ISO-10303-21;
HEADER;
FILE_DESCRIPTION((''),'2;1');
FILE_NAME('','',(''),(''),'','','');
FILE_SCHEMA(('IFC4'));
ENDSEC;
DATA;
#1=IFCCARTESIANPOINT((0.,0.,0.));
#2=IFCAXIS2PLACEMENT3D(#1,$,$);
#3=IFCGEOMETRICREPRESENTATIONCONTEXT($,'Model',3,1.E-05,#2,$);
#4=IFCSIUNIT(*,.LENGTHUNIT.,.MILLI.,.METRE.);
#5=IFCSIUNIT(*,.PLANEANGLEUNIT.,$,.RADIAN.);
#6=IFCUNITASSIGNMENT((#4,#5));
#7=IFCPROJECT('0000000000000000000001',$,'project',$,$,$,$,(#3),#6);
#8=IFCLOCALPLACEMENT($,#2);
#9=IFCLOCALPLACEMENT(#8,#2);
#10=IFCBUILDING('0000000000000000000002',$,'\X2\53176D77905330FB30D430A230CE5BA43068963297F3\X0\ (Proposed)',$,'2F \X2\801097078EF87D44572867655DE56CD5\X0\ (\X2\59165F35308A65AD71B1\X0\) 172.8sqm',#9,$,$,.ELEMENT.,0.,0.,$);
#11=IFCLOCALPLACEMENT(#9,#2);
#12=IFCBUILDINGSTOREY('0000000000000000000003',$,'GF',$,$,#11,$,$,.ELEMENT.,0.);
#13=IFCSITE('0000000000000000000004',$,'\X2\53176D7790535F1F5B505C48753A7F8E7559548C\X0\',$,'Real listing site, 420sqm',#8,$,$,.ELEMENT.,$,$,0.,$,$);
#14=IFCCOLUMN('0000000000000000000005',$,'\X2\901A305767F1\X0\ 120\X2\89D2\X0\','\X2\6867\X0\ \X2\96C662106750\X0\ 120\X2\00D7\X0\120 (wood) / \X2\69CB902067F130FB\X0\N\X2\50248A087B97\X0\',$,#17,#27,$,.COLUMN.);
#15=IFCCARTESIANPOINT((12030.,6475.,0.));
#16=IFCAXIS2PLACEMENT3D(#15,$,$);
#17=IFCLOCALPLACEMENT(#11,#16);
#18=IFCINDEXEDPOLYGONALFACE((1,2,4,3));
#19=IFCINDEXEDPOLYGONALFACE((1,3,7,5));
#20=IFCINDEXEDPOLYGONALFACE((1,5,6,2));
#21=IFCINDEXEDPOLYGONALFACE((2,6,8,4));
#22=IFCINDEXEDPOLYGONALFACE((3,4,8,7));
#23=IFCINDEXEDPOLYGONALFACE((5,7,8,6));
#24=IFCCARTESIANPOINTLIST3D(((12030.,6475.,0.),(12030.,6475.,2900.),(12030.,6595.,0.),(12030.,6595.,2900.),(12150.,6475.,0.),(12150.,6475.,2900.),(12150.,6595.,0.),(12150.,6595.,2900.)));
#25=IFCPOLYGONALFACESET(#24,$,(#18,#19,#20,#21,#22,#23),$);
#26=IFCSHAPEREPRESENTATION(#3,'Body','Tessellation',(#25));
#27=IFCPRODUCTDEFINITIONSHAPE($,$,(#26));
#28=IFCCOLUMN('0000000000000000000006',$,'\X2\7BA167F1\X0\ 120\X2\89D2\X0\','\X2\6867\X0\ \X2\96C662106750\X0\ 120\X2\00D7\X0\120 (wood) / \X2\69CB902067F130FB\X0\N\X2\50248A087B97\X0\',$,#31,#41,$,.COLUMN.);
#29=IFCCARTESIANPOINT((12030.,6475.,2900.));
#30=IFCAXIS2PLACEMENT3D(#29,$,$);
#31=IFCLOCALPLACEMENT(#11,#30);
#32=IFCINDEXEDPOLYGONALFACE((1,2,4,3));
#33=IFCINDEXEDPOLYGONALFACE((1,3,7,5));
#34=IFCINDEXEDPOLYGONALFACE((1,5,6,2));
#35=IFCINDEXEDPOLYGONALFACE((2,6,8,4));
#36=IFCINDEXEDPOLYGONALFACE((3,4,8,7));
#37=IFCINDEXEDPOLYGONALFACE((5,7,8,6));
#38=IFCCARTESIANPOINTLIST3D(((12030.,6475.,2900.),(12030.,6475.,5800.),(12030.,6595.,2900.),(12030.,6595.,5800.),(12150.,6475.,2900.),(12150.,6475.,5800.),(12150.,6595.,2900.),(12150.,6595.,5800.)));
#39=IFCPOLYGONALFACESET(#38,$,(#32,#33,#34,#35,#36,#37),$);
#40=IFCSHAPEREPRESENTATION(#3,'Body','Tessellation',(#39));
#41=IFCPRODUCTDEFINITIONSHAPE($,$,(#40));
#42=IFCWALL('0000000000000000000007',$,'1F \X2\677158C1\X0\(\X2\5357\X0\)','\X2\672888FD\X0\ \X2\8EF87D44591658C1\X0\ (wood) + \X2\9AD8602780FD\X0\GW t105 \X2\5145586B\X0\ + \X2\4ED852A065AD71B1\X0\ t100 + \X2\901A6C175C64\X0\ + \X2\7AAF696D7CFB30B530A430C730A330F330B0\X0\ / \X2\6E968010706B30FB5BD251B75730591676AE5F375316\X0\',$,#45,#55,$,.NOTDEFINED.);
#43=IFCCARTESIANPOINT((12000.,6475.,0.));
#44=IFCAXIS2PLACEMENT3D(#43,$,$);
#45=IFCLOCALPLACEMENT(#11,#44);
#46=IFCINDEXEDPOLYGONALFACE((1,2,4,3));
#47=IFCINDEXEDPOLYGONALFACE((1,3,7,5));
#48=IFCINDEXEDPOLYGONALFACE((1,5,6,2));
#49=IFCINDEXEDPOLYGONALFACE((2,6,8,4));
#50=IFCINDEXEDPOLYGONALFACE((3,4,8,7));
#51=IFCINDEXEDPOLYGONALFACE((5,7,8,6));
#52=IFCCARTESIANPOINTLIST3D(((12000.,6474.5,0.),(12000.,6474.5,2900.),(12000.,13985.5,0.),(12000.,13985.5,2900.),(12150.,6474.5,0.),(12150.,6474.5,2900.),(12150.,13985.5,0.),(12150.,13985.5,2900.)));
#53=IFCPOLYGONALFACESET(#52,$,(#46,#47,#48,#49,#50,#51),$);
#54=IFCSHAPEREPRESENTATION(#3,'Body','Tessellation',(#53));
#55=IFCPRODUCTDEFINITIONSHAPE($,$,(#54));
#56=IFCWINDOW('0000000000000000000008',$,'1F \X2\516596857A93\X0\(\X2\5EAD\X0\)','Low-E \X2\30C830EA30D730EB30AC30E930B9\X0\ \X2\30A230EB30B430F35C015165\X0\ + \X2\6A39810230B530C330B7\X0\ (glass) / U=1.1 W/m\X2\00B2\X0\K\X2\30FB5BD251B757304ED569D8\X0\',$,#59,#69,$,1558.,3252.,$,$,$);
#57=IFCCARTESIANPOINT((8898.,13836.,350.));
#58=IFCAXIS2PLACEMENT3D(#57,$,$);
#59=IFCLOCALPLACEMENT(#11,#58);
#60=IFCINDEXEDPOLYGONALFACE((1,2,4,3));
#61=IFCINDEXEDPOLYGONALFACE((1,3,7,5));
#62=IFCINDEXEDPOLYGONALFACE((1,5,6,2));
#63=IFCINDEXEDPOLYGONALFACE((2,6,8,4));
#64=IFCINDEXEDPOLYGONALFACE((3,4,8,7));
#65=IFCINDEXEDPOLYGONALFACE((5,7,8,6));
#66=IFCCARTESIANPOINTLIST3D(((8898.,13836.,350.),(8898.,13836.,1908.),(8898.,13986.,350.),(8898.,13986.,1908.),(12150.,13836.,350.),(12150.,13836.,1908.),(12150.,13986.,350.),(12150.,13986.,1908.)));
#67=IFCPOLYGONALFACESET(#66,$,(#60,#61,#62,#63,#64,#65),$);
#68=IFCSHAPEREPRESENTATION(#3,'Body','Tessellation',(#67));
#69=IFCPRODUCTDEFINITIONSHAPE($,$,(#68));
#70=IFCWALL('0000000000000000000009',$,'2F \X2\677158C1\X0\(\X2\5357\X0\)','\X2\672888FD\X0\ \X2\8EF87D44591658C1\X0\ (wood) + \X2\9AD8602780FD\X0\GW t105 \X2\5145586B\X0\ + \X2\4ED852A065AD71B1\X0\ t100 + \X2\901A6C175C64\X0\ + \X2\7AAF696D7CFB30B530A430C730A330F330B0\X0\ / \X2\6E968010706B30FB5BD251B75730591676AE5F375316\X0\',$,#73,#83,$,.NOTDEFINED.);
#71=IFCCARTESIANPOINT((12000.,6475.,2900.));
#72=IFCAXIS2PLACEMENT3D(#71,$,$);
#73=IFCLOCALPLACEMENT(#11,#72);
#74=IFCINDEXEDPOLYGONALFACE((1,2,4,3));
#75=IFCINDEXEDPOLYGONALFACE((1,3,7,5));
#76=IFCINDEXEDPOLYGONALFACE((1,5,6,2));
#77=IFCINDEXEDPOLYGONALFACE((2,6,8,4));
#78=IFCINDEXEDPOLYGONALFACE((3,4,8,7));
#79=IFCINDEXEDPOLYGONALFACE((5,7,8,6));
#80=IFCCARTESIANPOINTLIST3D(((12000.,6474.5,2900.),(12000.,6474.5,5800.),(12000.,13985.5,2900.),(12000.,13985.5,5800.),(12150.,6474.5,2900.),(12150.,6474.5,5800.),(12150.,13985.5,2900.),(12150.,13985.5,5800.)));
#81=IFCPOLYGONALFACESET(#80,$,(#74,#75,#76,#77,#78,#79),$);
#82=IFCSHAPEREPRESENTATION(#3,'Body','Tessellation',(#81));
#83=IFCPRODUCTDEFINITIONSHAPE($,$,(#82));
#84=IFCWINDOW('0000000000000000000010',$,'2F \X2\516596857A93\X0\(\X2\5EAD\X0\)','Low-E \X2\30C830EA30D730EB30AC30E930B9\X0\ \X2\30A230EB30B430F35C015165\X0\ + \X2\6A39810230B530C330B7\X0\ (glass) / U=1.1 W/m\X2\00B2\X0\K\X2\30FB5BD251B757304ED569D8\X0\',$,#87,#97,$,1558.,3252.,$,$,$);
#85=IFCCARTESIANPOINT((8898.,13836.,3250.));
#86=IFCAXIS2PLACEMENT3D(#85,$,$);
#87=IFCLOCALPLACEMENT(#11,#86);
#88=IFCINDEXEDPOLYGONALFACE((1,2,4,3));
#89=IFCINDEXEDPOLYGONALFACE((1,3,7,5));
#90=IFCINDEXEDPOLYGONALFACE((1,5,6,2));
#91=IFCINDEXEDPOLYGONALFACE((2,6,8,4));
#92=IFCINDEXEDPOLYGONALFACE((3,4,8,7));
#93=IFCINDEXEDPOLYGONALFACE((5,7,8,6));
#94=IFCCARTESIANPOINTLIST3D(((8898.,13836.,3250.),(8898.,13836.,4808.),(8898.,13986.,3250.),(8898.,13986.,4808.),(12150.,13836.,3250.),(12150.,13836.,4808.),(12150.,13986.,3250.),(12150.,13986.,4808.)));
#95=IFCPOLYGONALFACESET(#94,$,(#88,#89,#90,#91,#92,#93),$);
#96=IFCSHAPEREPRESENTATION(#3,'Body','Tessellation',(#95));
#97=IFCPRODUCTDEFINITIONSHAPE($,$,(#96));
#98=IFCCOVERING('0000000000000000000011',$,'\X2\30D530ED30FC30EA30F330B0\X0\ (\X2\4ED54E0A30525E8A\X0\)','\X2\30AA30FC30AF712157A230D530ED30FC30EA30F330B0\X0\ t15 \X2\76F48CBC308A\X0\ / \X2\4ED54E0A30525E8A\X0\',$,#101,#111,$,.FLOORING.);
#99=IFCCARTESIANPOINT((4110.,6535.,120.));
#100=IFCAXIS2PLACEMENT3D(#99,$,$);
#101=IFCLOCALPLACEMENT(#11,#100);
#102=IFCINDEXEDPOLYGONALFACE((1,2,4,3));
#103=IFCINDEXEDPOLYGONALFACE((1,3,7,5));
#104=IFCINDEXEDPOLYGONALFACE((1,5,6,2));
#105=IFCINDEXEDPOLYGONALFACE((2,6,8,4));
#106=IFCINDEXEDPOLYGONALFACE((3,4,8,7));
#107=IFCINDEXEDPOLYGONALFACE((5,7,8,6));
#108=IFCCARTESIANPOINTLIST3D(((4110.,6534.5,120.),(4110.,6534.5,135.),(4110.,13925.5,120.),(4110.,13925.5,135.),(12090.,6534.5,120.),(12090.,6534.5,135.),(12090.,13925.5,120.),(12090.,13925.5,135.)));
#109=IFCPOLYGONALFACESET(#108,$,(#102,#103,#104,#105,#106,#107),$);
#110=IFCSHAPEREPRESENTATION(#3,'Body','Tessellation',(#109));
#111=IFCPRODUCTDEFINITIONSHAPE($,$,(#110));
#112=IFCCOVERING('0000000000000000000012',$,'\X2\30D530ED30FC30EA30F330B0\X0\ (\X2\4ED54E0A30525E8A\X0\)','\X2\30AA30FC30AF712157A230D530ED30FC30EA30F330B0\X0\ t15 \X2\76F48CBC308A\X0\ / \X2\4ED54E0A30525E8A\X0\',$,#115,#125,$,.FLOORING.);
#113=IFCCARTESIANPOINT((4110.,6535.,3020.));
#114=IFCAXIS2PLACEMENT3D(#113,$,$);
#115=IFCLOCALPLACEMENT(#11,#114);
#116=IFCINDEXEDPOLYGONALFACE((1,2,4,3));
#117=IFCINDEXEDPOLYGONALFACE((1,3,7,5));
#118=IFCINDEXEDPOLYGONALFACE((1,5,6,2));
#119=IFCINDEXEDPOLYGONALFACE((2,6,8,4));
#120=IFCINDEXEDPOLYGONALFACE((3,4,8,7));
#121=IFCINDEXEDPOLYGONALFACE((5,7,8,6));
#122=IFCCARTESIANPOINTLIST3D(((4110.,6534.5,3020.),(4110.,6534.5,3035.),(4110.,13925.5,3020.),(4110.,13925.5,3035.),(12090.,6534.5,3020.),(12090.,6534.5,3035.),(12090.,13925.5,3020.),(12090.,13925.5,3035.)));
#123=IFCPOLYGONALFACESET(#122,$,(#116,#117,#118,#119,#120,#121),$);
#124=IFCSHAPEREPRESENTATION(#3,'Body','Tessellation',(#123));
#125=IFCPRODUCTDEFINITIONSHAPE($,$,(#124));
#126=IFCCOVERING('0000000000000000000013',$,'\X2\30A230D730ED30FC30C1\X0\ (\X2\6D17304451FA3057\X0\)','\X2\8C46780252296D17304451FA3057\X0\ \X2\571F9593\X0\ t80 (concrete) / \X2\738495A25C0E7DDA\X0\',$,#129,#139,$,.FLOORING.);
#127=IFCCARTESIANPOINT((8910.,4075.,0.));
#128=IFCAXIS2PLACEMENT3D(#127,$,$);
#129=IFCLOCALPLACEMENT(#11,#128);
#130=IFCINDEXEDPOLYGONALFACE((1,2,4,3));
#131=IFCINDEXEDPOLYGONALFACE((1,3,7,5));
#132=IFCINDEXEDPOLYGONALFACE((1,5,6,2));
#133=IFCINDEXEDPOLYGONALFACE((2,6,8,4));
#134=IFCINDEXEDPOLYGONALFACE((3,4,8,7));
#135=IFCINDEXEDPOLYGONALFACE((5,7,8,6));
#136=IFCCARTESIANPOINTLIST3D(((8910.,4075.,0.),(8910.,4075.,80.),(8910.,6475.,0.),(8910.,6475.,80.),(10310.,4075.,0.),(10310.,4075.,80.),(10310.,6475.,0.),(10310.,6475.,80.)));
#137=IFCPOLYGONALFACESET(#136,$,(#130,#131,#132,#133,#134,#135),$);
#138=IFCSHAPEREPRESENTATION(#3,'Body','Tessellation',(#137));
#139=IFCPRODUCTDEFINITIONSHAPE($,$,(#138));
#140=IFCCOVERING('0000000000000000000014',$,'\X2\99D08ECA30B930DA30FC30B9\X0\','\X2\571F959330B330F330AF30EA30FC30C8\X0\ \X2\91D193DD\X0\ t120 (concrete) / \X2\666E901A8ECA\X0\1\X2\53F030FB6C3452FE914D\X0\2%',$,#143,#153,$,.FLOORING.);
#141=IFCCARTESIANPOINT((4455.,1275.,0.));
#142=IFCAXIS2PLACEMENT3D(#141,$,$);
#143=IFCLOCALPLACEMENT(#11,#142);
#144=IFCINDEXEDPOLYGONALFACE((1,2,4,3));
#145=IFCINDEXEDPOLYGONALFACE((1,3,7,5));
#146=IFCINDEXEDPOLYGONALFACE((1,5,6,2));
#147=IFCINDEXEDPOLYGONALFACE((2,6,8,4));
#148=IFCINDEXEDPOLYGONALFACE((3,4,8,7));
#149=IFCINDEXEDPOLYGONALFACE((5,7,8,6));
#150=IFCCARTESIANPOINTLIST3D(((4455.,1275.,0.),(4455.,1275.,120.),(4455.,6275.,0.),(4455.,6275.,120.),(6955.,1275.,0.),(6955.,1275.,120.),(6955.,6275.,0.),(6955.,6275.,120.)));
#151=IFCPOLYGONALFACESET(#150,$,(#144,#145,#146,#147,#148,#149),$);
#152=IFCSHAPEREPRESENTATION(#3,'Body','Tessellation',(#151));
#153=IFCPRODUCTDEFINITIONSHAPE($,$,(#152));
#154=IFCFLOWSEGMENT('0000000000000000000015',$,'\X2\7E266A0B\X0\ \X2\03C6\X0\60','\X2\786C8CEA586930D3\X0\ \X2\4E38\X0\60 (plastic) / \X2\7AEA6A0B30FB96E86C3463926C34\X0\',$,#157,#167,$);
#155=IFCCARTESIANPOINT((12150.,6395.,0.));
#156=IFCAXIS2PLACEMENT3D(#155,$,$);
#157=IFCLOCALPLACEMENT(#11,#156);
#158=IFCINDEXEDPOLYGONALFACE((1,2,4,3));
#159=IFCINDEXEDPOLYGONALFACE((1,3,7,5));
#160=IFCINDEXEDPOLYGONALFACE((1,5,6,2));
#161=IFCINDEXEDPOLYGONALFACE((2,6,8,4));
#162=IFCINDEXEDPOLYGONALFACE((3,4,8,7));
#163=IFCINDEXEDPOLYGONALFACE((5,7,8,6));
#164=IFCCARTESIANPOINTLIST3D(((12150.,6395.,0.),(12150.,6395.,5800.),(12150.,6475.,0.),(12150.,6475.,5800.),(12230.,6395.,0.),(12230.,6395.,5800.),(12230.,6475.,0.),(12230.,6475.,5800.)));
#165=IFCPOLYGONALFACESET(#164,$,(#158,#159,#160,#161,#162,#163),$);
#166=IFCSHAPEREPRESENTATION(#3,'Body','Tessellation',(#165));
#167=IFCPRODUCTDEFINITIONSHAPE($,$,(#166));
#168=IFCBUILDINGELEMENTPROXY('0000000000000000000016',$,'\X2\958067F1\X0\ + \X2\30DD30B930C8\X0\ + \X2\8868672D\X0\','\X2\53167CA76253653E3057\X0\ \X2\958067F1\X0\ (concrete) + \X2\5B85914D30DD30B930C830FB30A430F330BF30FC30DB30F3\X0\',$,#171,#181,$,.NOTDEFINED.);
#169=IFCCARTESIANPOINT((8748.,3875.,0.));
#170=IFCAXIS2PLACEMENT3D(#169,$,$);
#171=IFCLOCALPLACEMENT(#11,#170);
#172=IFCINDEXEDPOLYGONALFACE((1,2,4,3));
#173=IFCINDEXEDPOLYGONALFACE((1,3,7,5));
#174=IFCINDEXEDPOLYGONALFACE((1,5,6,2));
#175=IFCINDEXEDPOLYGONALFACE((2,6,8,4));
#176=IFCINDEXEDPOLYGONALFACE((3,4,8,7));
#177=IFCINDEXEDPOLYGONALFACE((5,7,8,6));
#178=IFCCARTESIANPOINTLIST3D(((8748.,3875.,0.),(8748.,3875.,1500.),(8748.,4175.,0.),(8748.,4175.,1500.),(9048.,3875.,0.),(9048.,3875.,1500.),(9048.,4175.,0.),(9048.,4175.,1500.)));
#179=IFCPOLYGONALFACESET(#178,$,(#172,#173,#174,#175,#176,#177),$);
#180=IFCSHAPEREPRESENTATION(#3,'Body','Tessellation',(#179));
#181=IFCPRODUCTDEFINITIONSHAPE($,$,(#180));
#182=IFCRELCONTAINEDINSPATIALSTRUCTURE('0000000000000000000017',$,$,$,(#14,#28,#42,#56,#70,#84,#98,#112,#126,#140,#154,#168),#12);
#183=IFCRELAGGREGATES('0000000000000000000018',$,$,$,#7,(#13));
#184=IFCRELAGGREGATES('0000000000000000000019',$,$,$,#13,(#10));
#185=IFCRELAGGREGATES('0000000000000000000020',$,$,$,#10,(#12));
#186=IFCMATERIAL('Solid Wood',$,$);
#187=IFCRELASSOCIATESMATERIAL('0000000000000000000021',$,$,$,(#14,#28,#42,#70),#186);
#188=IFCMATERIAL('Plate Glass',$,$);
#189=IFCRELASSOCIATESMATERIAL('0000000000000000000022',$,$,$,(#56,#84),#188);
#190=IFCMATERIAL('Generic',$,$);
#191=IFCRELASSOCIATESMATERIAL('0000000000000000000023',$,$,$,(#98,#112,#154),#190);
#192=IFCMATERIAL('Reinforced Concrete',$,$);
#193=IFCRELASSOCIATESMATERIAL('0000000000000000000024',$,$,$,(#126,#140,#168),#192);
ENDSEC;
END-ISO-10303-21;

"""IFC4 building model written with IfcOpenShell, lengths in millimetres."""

from ifc_helpers import new_model, si_unit, frame, frame_2d, origin, place, context, project, spatial, rectangle, extrude, material, element, fill, save


model = new_model("IFC4")

# Units and contexts
model_context = context("Model", 3, precision=1e-05, world=origin())
ifc_project = project(units=[si_unit("LENGTHUNIT", "METRE", prefix="MILLI"), si_unit("PLANEANGLEUNIT", "RADIAN")], contexts=[model_context])

# Site, building, storey
site_placement = place(None, origin())
site = spatial("IfcSite", under=ifc_project, at=site_placement, Name="北海道弟子屈町美留和", ObjectType="Real listing site, 420sqm", CompositionType="ELEMENT", RefElevation=0.0)
building_placement = place(site_placement, origin())
building = spatial("IfcBuilding", under=site, at=building_placement, Name="北海道・ピアノ室と防音 (Proposed)", ObjectType="2F 耐震軸組在来工法 (外張り断熱) 172.8sqm", CompositionType="ELEMENT", ElevationOfRefHeight=0.0, ElevationOfTerrain=0.0)
storey_placement = place(building_placement, origin())
storey = spatial("IfcBuildingStorey", under=building, at=storey_placement, Name="GF", CompositionType="ELEMENT", Elevation=0.0)

# Columns
ifc_material_1 = material(Name="Solid Wood")
column_1_placement = place(storey_placement, frame((12030.0, 6475.0, 0.0)))
element("IfcColumn", 1, at=column_1_placement, inside=storey, material=ifc_material_1, Name="通し柱 120角", Description="桧 集成材 120×120 (wood) / 構造柱・N値計算", PredefinedType="COLUMN", context=model_context, shape_type="SweptSolid", body=[
    extrude(rectangle(XDim=120.0, YDim=120.0, at=frame_2d((60.0, 60.0))), frame((12030.0, 6475.0, 0.0)), (0.0, 0.0, 1.0), 2900.0),
])
column_2_placement = place(storey_placement, frame((12030.0, 6475.0, 2900.0)))
element("IfcColumn", 2, at=column_2_placement, inside=storey, material=ifc_material_1, Name="管柱 120角", Description="桧 集成材 120×120 (wood) / 構造柱・N値計算", PredefinedType="COLUMN", context=model_context, shape_type="SweptSolid", body=[
    extrude(rectangle(XDim=120.0, YDim=120.0, at=frame_2d((60.0, 60.0))), frame((12030.0, 6475.0, 2900.0)), (0.0, 0.0, 1.0), 2900.0),
])

# Wall, opening, window
wall_1_placement = place(storey_placement, frame((12000.0, 6475.0, 0.0)))
wall_1 = element("IfcWall", 3, at=wall_1_placement, inside=storey, material=ifc_material_1, Name="1F 東壁(南)", Description="木製 軸組外壁 (wood) + 高性能GW t105 充填 + 付加断熱 t100 + 通気層 + 窯業系サイディング / 準耐火・寒冷地外皮強化", PredefinedType="NOTDEFINED", context=model_context, shape_type="SweptSolid", body=[
    extrude(rectangle(XDim=150.0, YDim=7511.0, at=frame_2d((75.0, 3755.0))), frame((12000.0, 6475.0, 0.0)), (0.0, 0.0, 1.0), 2900.0),
])
opening_1_placement = place(storey_placement, frame((8898.0, 13836.0, 350.0)))
opening_1 = element("IfcOpeningElement", 4, at=opening_1_placement, cuts=wall_1, PredefinedType="NOTDEFINED", context=model_context, shape_type="SweptSolid", body=[
    extrude(rectangle(XDim=3252.0, YDim=150.0, at=frame_2d((1626.0, 75.0))), frame((8898.0, 13836.0, 350.0)), (0.0, 0.0, 1.0), 1558.0),
])
ifc_material_2 = material(Name="Plate Glass")
window_1_placement = place(storey_placement, frame((8898.0, 13836.0, 350.0)))
window_1 = element("IfcWindow", 5, at=window_1_placement, inside=storey, material=ifc_material_2, Name="1F 入隅窓(庭)", Description="Low-E トリプルガラス アルゴン封入 + 樹脂サッシ (glass) / U=1.1 W/m²K・寒冷地仕様", OverallHeight=1558.0, OverallWidth=3252.0, context=model_context, shape_type="SweptSolid", body=[
    extrude(rectangle(XDim=3252.0, YDim=150.0, at=frame_2d((1626.0, 75.0))), frame((8898.0, 13836.0, 350.0)), (0.0, 0.0, 1.0), 1558.0),
])
fill(opening_1, window_1)

# Wall, opening, window
wall_2_placement = place(storey_placement, frame((12000.0, 6475.0, 2900.0)))
wall_2 = element("IfcWall", 6, at=wall_2_placement, inside=storey, material=ifc_material_1, Name="2F 東壁(南)", Description="木製 軸組外壁 (wood) + 高性能GW t105 充填 + 付加断熱 t100 + 通気層 + 窯業系サイディング / 準耐火・寒冷地外皮強化", PredefinedType="NOTDEFINED", context=model_context, shape_type="SweptSolid", body=[
    extrude(rectangle(XDim=150.0, YDim=7511.0, at=frame_2d((75.0, 3755.0))), frame((12000.0, 6475.0, 2900.0)), (0.0, 0.0, 1.0), 2900.0),
])
opening_2_placement = place(storey_placement, frame((8898.0, 13836.0, 3250.0)))
opening_2 = element("IfcOpeningElement", 7, at=opening_2_placement, cuts=wall_2, PredefinedType="NOTDEFINED", context=model_context, shape_type="SweptSolid", body=[
    extrude(rectangle(XDim=3252.0, YDim=150.0, at=frame_2d((1626.0, 75.0))), frame((8898.0, 13836.0, 3250.0)), (0.0, 0.0, 1.0), 1558.0),
])
window_2_placement = place(storey_placement, frame((8898.0, 13836.0, 3250.0)))
window_2 = element("IfcWindow", 8, at=window_2_placement, inside=storey, material=ifc_material_2, Name="2F 入隅窓(庭)", Description="Low-E トリプルガラス アルゴン封入 + 樹脂サッシ (glass) / U=1.1 W/m²K・寒冷地仕様", OverallHeight=1558.0, OverallWidth=3252.0, context=model_context, shape_type="SweptSolid", body=[
    extrude(rectangle(XDim=3252.0, YDim=150.0, at=frame_2d((1626.0, 75.0))), frame((8898.0, 13836.0, 3250.0)), (0.0, 0.0, 1.0), 1558.0),
])
fill(opening_2, window_2)

# Coverings
ifc_material_3 = material(Name="Generic")
covering_1_placement = place(storey_placement, frame((4110.0, 6535.0, 120.0)))
element("IfcCovering", 9, at=covering_1_placement, inside=storey, material=ifc_material_3, Name="フローリング (仕上げ床)", Description="オーク無垢フローリング t15 直貼り / 仕上げ床", PredefinedType="FLOORING", context=model_context, shape_type="SweptSolid", body=[
    extrude(rectangle(XDim=7980.0, YDim=7391.0, at=frame_2d((3990.0, 3695.0))), frame((4110.0, 6535.0, 120.0)), (0.0, 0.0, 1.0), 15.0),
])
covering_2_placement = place(storey_placement, frame((4110.0, 6535.0, 3020.0)))
element("IfcCovering", 10, at=covering_2_placement, inside=storey, material=ifc_material_3, Name="フローリング (仕上げ床)", Description="オーク無垢フローリング t15 直貼り / 仕上げ床", PredefinedType="FLOORING", context=model_context, shape_type="SweptSolid", body=[
    extrude(rectangle(XDim=7980.0, YDim=7391.0, at=frame_2d((3990.0, 3695.0))), frame((4110.0, 6535.0, 3020.0)), (0.0, 0.0, 1.0), 15.0),
])
ifc_material_4 = material(Name="Reinforced Concrete")
covering_3_placement = place(storey_placement, frame((8910.0, 4075.0, 0.0)))
element("IfcCovering", 11, at=covering_3_placement, inside=storey, material=ifc_material_4, Name="アプローチ (洗い出し)", Description="豆砂利洗い出し 土間 t80 (concrete) / 玄関導線", PredefinedType="FLOORING", context=model_context, shape_type="SweptSolid", body=[
    extrude(rectangle(XDim=1400.0, YDim=2400.0, at=frame_2d((700.0, 1200.0))), frame((8910.0, 4075.0, 0.0)), (0.0, 0.0, 1.0), 80.0),
])
covering_4_placement = place(storey_placement, frame((4455.0, 1275.0, 0.0)))
element("IfcCovering", 12, at=covering_4_placement, inside=storey, material=ifc_material_4, Name="駐車スペース", Description="土間コンクリート 金鏝 t120 (concrete) / 普通車1台・水勾配2%", PredefinedType="FLOORING", context=model_context, shape_type="SweptSolid", body=[
    extrude(rectangle(XDim=2500.0, YDim=5000.0, at=frame_2d((1250.0, 2500.0))), frame((4455.0, 1275.0, 0.0)), (0.0, 0.0, 1.0), 120.0),
])

# Flow segment
flow_segment_placement = place(storey_placement, frame((12150.0, 6395.0, 0.0)))
element("IfcFlowSegment", 13, at=flow_segment_placement, inside=storey, material=ifc_material_3, Name="縦樋 φ60", Description="硬質塩ビ 丸60 (plastic) / 竪樋・雨水排水", context=model_context, shape_type="SweptSolid", body=[
    extrude(rectangle(XDim=80.0, YDim=80.0, at=frame_2d((40.0, 40.0))), frame((12150.0, 6395.0, 0.0)), (0.0, 0.0, 1.0), 5800.0),
])

# Building element proxy
proxy_placement = place(storey_placement, frame((8748.0, 3875.0, 0.0)))
element("IfcBuildingElementProxy", 14, at=proxy_placement, inside=storey, material=ifc_material_4, Name="門柱 + ポスト + 表札", Description="化粧打放し 門柱 (concrete) + 宅配ポスト・インターホン", PredefinedType="NOTDEFINED", context=model_context, shape_type="SweptSolid", body=[
    extrude(rectangle(XDim=300.0, YDim=300.0, at=frame_2d((150.0, 150.0))), frame((8748.0, 3875.0, 0.0)), (0.0, 0.0, 1.0), 1500.0),
])

save(model, "model.ifc")
